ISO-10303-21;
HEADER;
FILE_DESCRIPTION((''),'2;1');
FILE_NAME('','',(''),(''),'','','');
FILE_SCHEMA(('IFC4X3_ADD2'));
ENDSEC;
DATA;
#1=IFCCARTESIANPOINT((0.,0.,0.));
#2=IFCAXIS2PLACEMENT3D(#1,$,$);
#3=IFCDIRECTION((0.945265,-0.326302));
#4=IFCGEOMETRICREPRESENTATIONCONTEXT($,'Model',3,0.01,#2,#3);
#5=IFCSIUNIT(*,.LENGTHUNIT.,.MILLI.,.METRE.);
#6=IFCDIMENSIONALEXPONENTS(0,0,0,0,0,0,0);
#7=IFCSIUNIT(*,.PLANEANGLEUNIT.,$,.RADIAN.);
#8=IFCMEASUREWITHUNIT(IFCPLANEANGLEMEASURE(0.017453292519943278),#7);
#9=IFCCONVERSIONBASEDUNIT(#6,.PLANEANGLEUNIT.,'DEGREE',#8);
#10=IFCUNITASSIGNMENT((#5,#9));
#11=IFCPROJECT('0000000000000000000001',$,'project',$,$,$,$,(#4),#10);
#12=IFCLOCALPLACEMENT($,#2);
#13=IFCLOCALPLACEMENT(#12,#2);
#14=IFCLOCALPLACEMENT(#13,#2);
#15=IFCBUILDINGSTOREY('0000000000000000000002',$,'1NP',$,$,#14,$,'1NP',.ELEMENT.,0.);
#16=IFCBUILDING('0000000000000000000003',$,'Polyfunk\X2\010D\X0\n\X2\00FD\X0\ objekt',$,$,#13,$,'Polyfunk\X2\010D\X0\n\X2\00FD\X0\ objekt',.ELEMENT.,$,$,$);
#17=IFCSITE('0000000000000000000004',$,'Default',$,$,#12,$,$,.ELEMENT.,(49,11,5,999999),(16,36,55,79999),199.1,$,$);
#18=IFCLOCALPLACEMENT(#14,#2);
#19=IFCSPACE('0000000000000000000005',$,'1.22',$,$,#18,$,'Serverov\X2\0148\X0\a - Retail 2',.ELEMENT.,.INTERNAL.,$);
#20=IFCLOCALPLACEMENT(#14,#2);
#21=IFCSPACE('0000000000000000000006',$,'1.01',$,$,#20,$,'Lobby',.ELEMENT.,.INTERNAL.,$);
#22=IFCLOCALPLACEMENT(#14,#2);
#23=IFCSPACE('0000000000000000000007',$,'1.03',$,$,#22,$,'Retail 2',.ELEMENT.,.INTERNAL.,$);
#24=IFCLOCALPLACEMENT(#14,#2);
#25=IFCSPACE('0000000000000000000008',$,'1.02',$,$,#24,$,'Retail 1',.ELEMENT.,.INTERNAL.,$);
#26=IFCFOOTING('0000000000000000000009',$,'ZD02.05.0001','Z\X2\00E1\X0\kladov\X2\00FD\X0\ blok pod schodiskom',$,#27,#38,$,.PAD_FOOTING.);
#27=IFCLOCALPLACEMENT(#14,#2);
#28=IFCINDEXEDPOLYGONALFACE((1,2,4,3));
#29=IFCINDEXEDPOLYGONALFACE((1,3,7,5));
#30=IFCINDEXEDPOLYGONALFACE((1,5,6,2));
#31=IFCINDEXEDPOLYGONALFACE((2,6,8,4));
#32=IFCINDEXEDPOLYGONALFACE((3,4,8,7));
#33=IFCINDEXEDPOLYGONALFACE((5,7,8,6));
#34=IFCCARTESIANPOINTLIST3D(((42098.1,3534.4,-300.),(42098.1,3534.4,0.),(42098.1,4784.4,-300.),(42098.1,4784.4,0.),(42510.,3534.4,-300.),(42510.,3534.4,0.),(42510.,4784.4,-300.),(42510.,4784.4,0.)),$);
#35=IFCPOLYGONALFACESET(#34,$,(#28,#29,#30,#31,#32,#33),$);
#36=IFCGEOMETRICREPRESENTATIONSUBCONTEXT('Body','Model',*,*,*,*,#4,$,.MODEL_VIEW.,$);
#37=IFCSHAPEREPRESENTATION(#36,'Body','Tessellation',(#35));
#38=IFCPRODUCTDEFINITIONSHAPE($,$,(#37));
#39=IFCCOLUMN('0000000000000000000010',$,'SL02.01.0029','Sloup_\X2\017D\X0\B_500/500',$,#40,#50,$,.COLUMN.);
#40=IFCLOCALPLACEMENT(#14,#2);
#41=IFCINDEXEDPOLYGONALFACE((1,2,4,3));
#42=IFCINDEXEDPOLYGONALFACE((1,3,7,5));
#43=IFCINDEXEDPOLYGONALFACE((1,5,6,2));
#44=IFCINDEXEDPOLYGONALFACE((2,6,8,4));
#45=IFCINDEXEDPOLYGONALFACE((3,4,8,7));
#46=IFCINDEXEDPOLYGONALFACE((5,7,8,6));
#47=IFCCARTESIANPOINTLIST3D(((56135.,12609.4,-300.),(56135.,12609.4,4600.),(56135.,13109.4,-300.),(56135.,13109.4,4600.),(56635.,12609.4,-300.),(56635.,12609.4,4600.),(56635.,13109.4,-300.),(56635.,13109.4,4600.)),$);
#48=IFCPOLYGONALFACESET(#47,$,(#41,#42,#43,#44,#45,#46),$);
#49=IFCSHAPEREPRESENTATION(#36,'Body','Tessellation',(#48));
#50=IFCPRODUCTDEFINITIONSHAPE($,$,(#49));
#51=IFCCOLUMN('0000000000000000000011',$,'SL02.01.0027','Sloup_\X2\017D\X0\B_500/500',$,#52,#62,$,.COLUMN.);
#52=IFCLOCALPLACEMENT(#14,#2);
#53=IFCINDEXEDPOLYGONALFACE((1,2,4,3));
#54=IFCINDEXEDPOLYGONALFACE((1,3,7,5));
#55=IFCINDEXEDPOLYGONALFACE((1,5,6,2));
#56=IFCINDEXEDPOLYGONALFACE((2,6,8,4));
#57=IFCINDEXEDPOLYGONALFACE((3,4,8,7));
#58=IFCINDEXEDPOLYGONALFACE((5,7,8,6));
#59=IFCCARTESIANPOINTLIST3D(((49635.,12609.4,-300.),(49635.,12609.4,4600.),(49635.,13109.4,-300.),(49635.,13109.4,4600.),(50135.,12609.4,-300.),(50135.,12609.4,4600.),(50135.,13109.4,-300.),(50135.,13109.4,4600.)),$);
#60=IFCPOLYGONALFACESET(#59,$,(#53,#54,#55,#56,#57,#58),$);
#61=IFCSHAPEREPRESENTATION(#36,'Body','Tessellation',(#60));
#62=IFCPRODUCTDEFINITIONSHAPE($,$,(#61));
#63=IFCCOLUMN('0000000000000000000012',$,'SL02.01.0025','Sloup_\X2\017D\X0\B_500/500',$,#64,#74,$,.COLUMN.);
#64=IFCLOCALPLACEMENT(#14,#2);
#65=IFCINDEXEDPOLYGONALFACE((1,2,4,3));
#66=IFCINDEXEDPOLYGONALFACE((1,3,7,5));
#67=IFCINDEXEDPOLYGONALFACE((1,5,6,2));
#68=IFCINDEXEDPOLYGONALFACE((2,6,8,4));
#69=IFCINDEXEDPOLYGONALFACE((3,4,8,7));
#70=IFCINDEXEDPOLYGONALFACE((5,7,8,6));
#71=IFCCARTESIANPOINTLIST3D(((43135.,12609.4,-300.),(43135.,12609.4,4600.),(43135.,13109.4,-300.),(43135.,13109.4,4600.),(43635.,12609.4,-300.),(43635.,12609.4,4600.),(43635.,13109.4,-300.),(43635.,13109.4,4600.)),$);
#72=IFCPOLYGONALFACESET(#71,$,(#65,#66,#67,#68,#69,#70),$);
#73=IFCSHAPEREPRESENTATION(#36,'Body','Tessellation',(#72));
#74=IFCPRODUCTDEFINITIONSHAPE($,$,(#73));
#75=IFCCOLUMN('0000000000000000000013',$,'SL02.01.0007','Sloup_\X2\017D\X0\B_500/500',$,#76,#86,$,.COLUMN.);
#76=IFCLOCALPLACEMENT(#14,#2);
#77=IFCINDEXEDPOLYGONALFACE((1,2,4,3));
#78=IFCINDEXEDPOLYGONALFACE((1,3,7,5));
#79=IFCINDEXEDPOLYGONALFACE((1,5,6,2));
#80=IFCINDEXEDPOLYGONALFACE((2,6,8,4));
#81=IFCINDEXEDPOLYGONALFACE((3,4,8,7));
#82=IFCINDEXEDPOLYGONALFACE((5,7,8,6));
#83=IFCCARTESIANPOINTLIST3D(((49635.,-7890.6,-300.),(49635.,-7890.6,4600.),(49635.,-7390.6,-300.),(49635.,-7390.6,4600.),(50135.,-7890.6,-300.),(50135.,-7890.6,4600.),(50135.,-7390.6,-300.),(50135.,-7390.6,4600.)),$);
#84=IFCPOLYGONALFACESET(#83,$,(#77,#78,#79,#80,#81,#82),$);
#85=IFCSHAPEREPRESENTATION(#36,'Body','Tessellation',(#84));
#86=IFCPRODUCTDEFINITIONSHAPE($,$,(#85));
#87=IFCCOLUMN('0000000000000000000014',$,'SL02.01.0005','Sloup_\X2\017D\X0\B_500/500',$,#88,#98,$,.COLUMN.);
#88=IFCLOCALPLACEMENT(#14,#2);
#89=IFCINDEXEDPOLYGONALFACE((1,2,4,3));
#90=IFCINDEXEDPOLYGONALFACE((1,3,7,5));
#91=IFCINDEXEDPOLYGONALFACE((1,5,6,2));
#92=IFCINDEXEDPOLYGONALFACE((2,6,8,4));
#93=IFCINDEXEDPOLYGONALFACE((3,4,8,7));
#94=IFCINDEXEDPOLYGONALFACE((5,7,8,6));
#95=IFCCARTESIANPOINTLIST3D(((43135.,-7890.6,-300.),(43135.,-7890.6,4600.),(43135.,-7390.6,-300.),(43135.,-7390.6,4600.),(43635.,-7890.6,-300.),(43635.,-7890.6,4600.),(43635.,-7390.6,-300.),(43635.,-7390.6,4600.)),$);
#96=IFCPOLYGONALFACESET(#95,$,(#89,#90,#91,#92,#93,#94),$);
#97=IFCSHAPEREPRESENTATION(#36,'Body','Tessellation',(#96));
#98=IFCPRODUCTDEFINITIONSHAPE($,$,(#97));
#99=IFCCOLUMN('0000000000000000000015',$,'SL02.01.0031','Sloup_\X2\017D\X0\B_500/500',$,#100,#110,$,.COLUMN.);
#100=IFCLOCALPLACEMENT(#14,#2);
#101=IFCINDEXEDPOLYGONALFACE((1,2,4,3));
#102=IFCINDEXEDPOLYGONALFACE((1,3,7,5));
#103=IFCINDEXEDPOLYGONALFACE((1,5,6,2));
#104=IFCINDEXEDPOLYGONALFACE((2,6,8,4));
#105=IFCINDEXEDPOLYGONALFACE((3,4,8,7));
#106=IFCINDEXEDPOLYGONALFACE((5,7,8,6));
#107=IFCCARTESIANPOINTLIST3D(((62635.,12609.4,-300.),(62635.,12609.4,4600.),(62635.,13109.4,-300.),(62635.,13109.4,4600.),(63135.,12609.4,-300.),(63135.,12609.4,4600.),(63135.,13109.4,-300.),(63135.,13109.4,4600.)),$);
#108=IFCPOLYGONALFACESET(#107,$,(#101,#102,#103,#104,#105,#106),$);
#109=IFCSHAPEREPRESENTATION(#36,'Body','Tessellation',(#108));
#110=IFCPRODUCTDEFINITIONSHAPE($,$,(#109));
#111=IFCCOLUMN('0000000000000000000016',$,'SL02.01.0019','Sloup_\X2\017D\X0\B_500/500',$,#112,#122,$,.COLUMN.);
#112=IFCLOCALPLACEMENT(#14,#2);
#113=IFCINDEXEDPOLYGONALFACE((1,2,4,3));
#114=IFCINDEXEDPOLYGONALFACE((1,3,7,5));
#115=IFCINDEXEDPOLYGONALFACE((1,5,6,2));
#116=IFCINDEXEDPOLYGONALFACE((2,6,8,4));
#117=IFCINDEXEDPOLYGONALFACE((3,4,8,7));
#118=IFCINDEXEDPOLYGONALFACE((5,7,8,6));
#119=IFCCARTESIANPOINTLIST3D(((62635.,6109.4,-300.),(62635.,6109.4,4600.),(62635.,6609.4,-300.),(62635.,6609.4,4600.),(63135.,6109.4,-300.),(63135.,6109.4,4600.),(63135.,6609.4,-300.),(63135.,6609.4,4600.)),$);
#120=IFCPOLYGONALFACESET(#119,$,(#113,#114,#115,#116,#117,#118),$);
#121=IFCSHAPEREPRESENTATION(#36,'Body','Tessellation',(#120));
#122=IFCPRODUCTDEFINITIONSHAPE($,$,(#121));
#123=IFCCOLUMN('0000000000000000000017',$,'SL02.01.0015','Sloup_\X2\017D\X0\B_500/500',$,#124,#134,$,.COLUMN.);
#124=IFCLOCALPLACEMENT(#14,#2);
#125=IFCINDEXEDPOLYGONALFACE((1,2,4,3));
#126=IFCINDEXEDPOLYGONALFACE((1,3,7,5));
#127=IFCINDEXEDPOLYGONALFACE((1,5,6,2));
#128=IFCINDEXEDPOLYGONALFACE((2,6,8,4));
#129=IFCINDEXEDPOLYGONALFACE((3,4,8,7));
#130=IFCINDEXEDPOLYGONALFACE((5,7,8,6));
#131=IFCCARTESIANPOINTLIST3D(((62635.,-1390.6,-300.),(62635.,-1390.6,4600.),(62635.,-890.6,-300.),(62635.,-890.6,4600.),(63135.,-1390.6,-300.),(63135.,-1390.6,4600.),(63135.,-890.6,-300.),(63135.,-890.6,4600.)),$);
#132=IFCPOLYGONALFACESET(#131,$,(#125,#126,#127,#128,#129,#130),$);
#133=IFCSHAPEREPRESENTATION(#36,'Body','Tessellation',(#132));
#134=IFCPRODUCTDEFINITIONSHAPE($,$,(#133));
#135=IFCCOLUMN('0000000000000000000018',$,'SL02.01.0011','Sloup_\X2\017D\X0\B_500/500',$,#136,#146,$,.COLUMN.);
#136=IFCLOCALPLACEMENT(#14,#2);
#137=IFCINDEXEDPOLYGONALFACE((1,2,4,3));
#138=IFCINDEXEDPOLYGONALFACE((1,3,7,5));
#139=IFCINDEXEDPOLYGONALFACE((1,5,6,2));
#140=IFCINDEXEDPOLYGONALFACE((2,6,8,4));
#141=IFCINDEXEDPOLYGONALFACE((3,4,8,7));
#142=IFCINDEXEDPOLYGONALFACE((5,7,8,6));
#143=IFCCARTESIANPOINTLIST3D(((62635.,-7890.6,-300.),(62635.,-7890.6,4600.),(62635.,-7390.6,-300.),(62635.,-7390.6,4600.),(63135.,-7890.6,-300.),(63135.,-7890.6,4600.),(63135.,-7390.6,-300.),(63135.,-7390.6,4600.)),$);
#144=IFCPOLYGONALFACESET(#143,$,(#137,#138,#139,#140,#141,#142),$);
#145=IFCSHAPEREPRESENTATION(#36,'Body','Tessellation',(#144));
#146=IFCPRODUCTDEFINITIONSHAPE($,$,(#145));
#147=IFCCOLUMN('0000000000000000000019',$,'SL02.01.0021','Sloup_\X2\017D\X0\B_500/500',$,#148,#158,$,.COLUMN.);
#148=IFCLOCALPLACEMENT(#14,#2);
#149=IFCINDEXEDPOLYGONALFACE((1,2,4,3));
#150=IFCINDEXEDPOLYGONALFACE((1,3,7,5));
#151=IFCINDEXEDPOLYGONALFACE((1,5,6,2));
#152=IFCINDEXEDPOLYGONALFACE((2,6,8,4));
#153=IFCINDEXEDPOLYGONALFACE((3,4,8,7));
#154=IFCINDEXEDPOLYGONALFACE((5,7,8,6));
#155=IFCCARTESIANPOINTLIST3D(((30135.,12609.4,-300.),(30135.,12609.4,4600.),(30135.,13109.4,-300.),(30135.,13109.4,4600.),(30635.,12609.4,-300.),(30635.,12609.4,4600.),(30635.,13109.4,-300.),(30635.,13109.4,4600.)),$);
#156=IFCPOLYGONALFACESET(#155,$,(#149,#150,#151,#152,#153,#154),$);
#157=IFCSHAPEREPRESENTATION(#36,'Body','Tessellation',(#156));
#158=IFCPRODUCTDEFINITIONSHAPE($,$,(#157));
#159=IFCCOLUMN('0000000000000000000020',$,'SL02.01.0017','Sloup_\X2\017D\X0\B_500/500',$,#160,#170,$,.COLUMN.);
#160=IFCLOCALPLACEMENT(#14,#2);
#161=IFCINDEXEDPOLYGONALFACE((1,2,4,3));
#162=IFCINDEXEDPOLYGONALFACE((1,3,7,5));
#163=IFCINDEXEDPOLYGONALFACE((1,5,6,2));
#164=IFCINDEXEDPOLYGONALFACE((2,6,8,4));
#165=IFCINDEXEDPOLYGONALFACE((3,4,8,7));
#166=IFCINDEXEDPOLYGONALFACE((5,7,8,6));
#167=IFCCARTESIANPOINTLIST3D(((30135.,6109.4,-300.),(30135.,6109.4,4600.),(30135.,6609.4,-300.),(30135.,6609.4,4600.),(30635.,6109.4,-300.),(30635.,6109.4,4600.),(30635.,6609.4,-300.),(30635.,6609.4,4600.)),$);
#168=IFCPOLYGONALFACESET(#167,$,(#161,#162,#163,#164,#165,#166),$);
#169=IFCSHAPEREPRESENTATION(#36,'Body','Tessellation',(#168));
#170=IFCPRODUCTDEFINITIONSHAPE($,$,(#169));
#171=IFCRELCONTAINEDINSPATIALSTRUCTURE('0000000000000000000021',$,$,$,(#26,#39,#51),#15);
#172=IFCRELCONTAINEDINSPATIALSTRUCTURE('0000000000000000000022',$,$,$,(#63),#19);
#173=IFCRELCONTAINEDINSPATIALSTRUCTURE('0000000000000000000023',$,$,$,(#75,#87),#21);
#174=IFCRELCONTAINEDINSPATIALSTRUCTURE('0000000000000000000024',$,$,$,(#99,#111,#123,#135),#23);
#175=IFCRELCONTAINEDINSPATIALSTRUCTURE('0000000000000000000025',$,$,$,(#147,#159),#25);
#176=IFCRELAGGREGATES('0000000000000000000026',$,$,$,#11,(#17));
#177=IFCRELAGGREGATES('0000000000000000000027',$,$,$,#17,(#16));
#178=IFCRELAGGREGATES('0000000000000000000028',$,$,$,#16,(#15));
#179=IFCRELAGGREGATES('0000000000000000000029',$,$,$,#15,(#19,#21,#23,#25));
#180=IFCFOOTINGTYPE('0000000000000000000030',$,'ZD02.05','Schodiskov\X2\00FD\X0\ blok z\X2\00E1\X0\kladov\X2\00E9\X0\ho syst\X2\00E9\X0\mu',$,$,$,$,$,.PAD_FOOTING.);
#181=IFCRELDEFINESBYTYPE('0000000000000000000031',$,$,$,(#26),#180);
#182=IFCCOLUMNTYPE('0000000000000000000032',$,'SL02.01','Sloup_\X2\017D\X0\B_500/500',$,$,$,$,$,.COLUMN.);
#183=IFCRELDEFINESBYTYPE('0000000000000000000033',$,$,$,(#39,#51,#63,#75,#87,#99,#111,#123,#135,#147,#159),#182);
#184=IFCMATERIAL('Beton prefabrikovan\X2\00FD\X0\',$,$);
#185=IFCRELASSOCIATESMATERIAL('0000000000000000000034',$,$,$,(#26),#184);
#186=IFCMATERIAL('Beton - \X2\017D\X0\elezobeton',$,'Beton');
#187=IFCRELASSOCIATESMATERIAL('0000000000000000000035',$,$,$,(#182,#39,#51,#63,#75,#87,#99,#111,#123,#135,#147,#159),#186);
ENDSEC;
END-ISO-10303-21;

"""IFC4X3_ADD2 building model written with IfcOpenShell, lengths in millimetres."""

from ifc_helpers import new_model, entity, si_unit, converted_unit, direction, frame, frame_2d, origin, origin_2d_with_axis, place, context, subcontext, project, spatial, rectangle, extrude, source, transform, mapped, material, material_profile, profile_set, profile_usage, type_object, element, save


model = new_model("IFC4X3_ADD2")

# Units and contexts
model_context = context("Model", 3, precision=0.01, world=origin(), true_north=direction((0.945265, -0.326302)))
body_context = subcontext(model_context, "Body", "Model", "MODEL_VIEW")
ifc_project = project(units=[si_unit("LENGTHUNIT", "METRE", prefix="MILLI"), converted_unit("PLANEANGLEUNIT", "DEGREE", entity("IfcPlaneAngleMeasure", 0.017453292519943278), si_unit("PLANEANGLEUNIT", "RADIAN"), dimensions=[0, 0, 0, 0, 0, 0, 0])], contexts=[model_context])

# Site, building, storey
site_placement = place(None, origin())
site = spatial("IfcSite", under=ifc_project, at=site_placement, Name="Default", CompositionType="ELEMENT", RefLatitude=(49, 11, 5, 999999), RefLongitude=(16, 36, 55, 79999), RefElevation=199.1)
building_placement = place(site_placement, origin())
building = spatial("IfcBuilding", under=site, at=building_placement, Name="Polyfunkčný objekt", LongName="Polyfunkčný objekt", CompositionType="ELEMENT")
storey_placement = place(building_placement, origin())
storey = spatial("IfcBuildingStorey", under=building, at=storey_placement, Name="1NP", LongName="1NP", CompositionType="ELEMENT", Elevation=0.0)

# Footing
ifc_material_1 = material(Name="Beton prefabrikovaný")
footing_type = type_object("IfcFootingType", Name="ZD02.05", Description="Schodiskový blok základového systému", PredefinedType="PAD_FOOTING")
footing_placement = place(storey_placement, origin())
element("IfcFooting", 1, at=footing_placement, inside=storey, type_object=footing_type, material=ifc_material_1, Name="ZD02.05.0001", Description="Základový blok pod schodiskom", PredefinedType="PAD_FOOTING", context=body_context, shape_type="SweptSolid", body=[
    extrude(rectangle(XDim=1250.0, YDim=411.8, at=frame_2d((0.0, 0.0), x_axis=(1.0, 0.0))), frame((42304.0, 4159.4, -300.0), z_axis=(0.0, 0.0, 1.0), x_axis=(0.0, -1.0, 0.0)), (0.0, 0.0, 1.0), 300.0),
])

# Columns
ifc_material_2 = material(Name="Beton - Železobeton", Category="Beton")
ifc_material_profile = material_profile(ifc_material_2, rectangle(XDim=500.0, YDim=500.0, at=frame_2d((0.0, 0.0), x_axis=(1.0, 0.0))), Name="Sloup_ŽB_500/500")
ifc_profile_set = profile_set([ifc_material_profile], Name="Sloup_ŽB_500/500")
ifc_profile_usage = profile_usage(ifc_profile_set)
column_type = type_object("IfcColumnType", Name="SL02.01", Description="Sloup_ŽB_500/500", PredefinedType="COLUMN", material=ifc_profile_set)
shared_shape_1 = source(origin(), body_context, "Body", "SweptSolid", [
    extrude(rectangle(XDim=500.0, YDim=500.0, at=frame_2d((0.0, 83.3), x_axis=(1.0, 0.0))), frame((56385.0, 12776.1, -300.0)), (0.0, 0.0, 1.0), 4900.0),
])
column_1_placement = place(storey_placement, origin())
element("IfcColumn", 2, at=column_1_placement, inside=storey, type_object=column_type, material=ifc_profile_usage, Name="SL02.01.0029", Description="Sloup_ŽB_500/500", PredefinedType="COLUMN", context=body_context, shape_type="MappedRepresentation", body=[
    mapped(shared_shape_1, transform((0.0, 0.0, 0.0), scale=1.0)),
])
shared_shape_2 = source(origin(), body_context, "Body", "SweptSolid", [
    extrude(rectangle(XDim=500.0, YDim=500.0, at=frame_2d((0.0, -50.0), x_axis=(1.0, 0.0))), frame((49885.0, 12809.4, -300.0), z_axis=(0.0, 0.0, 1.0), x_axis=(-1.0, 0.0, 0.0)), (0.0, 0.0, 1.0), 4900.0),
])
column_2_placement = place(storey_placement, origin())
element("IfcColumn", 3, at=column_2_placement, inside=storey, type_object=column_type, material=ifc_profile_usage, Name="SL02.01.0027", Description="Sloup_ŽB_500/500", PredefinedType="COLUMN", context=body_context, shape_type="MappedRepresentation", body=[
    mapped(shared_shape_2, transform((0.0, 0.0, 0.0), scale=1.0)),
])

# Shared definitions
space_1_placement = place(storey_placement, origin())
space_1 = spatial("IfcSpace", under=storey, at=space_1_placement, Name="1.22", LongName="Serverovňa - Retail 2", CompositionType="ELEMENT", PredefinedType="INTERNAL")

# Column
shared_shape_3 = source(origin(), body_context, "Body", "SweptSolid", [
    extrude(rectangle(XDim=500.0, YDim=500.0, at=origin_2d_with_axis()), frame((43385.0, 12859.4, -300.0), z_axis=(0.0, 0.0, 1.0), x_axis=(0.0, 1.0, 0.0)), (0.0, 0.0, 1.0), 4900.0),
])
column_3_placement = place(storey_placement, origin())
element("IfcColumn", 4, at=column_3_placement, inside=space_1, type_object=column_type, material=ifc_profile_usage, Name="SL02.01.0025", Description="Sloup_ŽB_500/500", PredefinedType="COLUMN", context=body_context, shape_type="MappedRepresentation", body=[
    mapped(shared_shape_3, transform((0.0, 0.0, 0.0), scale=1.0)),
])

# Shared definitions
space_2_placement = place(storey_placement, origin())
space_2 = spatial("IfcSpace", under=storey, at=space_2_placement, Name="1.01", LongName="Lobby", CompositionType="ELEMENT", PredefinedType="INTERNAL")

# Columns
shared_shape_4 = source(origin(), body_context, "Body", "SweptSolid", [
    extrude(rectangle(XDim=500.0, YDim=500.0, at=frame_2d((0.0, 0.0), x_axis=(1.0, 0.0))), frame((49885.0, -7640.6, -300.0)), (0.0, 0.0, 1.0), 4900.0),
])
column_4_placement = place(storey_placement, origin())
element("IfcColumn", 5, at=column_4_placement, inside=space_2, type_object=column_type, material=ifc_profile_usage, Name="SL02.01.0007", Description="Sloup_ŽB_500/500", PredefinedType="COLUMN", context=body_context, shape_type="MappedRepresentation", body=[
    mapped(shared_shape_4, transform((0.0, 0.0, 0.0), scale=1.0)),
])
shared_shape_5 = source(origin(), body_context, "Body", "SweptSolid", [
    extrude(rectangle(XDim=500.0, YDim=500.0, at=origin_2d_with_axis()), frame((43385.0, -7640.6, -300.0)), (0.0, 0.0, 1.0), 4900.0),
])
column_5_placement = place(storey_placement, origin())
element("IfcColumn", 6, at=column_5_placement, inside=space_2, type_object=column_type, material=ifc_profile_usage, Name="SL02.01.0005", Description="Sloup_ŽB_500/500", PredefinedType="COLUMN", context=body_context, shape_type="MappedRepresentation", body=[
    mapped(shared_shape_5, transform((0.0, 0.0, 0.0), scale=1.0)),
])

# Shared definitions
space_3_placement = place(storey_placement, origin())
space_3 = spatial("IfcSpace", under=storey, at=space_3_placement, Name="1.03", LongName="Retail 2", CompositionType="ELEMENT", PredefinedType="INTERNAL")

# Columns
shared_shape_6 = source(origin(), body_context, "Body", "SweptSolid", [
    extrude(rectangle(XDim=500.0, YDim=500.0, at=origin_2d_with_axis()), frame((62885.0, 12859.4, -300.0), z_axis=(0.0, 0.0, 1.0), x_axis=(-1.0, 0.0, 0.0)), (0.0, 0.0, 1.0), 4900.0),
])
column_6_placement = place(storey_placement, origin())
element("IfcColumn", 7, at=column_6_placement, inside=space_3, type_object=column_type, material=ifc_profile_usage, Name="SL02.01.0031", Description="Sloup_ŽB_500/500", PredefinedType="COLUMN", context=body_context, shape_type="MappedRepresentation", body=[
    mapped(shared_shape_6, transform((0.0, 0.0, 0.0), scale=1.0)),
])
shared_shape_7 = source(origin(), body_context, "Body", "SweptSolid", [
    extrude(rectangle(XDim=500.0, YDim=500.0, at=origin_2d_with_axis()), frame((62885.0, 6359.4, -300.0), z_axis=(0.0, 0.0, 1.0), x_axis=(0.0, -1.0, 0.0)), (0.0, 0.0, 1.0), 4900.0),
])
column_7_placement = place(storey_placement, origin())
element("IfcColumn", 8, at=column_7_placement, inside=space_3, type_object=column_type, material=ifc_profile_usage, Name="SL02.01.0019", Description="Sloup_ŽB_500/500", PredefinedType="COLUMN", context=body_context, shape_type="MappedRepresentation", body=[
    mapped(shared_shape_7, transform((0.0, 0.0, 0.0), scale=1.0)),
])
shared_shape_8 = source(origin(), body_context, "Body", "SweptSolid", [
    extrude(rectangle(XDim=500.0, YDim=500.0, at=origin_2d_with_axis()), frame((62885.0, -1140.6, -300.0), z_axis=(0.0, 0.0, 1.0), x_axis=(0.0, -1.0, 0.0)), (0.0, 0.0, 1.0), 4900.0),
])
column_8_placement = place(storey_placement, origin())
element("IfcColumn", 9, at=column_8_placement, inside=space_3, type_object=column_type, material=ifc_profile_usage, Name="SL02.01.0015", Description="Sloup_ŽB_500/500", PredefinedType="COLUMN", context=body_context, shape_type="MappedRepresentation", body=[
    mapped(shared_shape_8, transform((0.0, 0.0, 0.0), scale=1.0)),
])
shared_shape_9 = source(origin(), body_context, "Body", "SweptSolid", [
    extrude(rectangle(XDim=500.0, YDim=500.0, at=origin_2d_with_axis()), frame((62885.0, -7640.6, -300.0), z_axis=(0.0, 0.0, 1.0), x_axis=(-1.0, 0.0, 0.0)), (0.0, 0.0, 1.0), 4900.0),
])
column_9_placement = place(storey_placement, origin())
element("IfcColumn", 10, at=column_9_placement, inside=space_3, type_object=column_type, material=ifc_profile_usage, Name="SL02.01.0011", Description="Sloup_ŽB_500/500", PredefinedType="COLUMN", context=body_context, shape_type="MappedRepresentation", body=[
    mapped(shared_shape_9, transform((0.0, 0.0, 0.0), scale=1.0)),
])

# Shared definitions
space_4_placement = place(storey_placement, origin())
space_4 = spatial("IfcSpace", under=storey, at=space_4_placement, Name="1.02", LongName="Retail 1", CompositionType="ELEMENT", PredefinedType="INTERNAL")

# Columns
shared_shape_10 = source(origin(), body_context, "Body", "SweptSolid", [
    extrude(rectangle(XDim=500.0, YDim=500.0, at=origin_2d_with_axis()), frame((30385.0, 12859.4, -300.0), z_axis=(0.0, 0.0, 1.0), x_axis=(-1.0, 0.0, 0.0)), (0.0, 0.0, 1.0), 4900.0),
])
column_10_placement = place(storey_placement, origin())
element("IfcColumn", 11, at=column_10_placement, inside=space_4, type_object=column_type, material=ifc_profile_usage, Name="SL02.01.0021", Description="Sloup_ŽB_500/500", PredefinedType="COLUMN", context=body_context, shape_type="MappedRepresentation", body=[
    mapped(shared_shape_10, transform((0.0, 0.0, 0.0), scale=1.0)),
])
shared_shape_11 = source(origin(), body_context, "Body", "SweptSolid", [
    extrude(rectangle(XDim=500.0, YDim=500.0, at=frame_2d((0.0, 0.0), x_axis=(1.0, 0.0))), frame((30385.0, 6359.4, -300.0), z_axis=(0.0, 0.0, 1.0), x_axis=(0.0, -1.0, 0.0)), (0.0, 0.0, 1.0), 4900.0),
])
column_11_placement = place(storey_placement, origin())
element("IfcColumn", 12, at=column_11_placement, inside=space_4, type_object=column_type, material=ifc_profile_usage, Name="SL02.01.0017", Description="Sloup_ŽB_500/500", PredefinedType="COLUMN", context=body_context, shape_type="MappedRepresentation", body=[
    mapped(shared_shape_11, transform((0.0, 0.0, 0.0), scale=1.0)),
])

save(model, "model.ifc")
